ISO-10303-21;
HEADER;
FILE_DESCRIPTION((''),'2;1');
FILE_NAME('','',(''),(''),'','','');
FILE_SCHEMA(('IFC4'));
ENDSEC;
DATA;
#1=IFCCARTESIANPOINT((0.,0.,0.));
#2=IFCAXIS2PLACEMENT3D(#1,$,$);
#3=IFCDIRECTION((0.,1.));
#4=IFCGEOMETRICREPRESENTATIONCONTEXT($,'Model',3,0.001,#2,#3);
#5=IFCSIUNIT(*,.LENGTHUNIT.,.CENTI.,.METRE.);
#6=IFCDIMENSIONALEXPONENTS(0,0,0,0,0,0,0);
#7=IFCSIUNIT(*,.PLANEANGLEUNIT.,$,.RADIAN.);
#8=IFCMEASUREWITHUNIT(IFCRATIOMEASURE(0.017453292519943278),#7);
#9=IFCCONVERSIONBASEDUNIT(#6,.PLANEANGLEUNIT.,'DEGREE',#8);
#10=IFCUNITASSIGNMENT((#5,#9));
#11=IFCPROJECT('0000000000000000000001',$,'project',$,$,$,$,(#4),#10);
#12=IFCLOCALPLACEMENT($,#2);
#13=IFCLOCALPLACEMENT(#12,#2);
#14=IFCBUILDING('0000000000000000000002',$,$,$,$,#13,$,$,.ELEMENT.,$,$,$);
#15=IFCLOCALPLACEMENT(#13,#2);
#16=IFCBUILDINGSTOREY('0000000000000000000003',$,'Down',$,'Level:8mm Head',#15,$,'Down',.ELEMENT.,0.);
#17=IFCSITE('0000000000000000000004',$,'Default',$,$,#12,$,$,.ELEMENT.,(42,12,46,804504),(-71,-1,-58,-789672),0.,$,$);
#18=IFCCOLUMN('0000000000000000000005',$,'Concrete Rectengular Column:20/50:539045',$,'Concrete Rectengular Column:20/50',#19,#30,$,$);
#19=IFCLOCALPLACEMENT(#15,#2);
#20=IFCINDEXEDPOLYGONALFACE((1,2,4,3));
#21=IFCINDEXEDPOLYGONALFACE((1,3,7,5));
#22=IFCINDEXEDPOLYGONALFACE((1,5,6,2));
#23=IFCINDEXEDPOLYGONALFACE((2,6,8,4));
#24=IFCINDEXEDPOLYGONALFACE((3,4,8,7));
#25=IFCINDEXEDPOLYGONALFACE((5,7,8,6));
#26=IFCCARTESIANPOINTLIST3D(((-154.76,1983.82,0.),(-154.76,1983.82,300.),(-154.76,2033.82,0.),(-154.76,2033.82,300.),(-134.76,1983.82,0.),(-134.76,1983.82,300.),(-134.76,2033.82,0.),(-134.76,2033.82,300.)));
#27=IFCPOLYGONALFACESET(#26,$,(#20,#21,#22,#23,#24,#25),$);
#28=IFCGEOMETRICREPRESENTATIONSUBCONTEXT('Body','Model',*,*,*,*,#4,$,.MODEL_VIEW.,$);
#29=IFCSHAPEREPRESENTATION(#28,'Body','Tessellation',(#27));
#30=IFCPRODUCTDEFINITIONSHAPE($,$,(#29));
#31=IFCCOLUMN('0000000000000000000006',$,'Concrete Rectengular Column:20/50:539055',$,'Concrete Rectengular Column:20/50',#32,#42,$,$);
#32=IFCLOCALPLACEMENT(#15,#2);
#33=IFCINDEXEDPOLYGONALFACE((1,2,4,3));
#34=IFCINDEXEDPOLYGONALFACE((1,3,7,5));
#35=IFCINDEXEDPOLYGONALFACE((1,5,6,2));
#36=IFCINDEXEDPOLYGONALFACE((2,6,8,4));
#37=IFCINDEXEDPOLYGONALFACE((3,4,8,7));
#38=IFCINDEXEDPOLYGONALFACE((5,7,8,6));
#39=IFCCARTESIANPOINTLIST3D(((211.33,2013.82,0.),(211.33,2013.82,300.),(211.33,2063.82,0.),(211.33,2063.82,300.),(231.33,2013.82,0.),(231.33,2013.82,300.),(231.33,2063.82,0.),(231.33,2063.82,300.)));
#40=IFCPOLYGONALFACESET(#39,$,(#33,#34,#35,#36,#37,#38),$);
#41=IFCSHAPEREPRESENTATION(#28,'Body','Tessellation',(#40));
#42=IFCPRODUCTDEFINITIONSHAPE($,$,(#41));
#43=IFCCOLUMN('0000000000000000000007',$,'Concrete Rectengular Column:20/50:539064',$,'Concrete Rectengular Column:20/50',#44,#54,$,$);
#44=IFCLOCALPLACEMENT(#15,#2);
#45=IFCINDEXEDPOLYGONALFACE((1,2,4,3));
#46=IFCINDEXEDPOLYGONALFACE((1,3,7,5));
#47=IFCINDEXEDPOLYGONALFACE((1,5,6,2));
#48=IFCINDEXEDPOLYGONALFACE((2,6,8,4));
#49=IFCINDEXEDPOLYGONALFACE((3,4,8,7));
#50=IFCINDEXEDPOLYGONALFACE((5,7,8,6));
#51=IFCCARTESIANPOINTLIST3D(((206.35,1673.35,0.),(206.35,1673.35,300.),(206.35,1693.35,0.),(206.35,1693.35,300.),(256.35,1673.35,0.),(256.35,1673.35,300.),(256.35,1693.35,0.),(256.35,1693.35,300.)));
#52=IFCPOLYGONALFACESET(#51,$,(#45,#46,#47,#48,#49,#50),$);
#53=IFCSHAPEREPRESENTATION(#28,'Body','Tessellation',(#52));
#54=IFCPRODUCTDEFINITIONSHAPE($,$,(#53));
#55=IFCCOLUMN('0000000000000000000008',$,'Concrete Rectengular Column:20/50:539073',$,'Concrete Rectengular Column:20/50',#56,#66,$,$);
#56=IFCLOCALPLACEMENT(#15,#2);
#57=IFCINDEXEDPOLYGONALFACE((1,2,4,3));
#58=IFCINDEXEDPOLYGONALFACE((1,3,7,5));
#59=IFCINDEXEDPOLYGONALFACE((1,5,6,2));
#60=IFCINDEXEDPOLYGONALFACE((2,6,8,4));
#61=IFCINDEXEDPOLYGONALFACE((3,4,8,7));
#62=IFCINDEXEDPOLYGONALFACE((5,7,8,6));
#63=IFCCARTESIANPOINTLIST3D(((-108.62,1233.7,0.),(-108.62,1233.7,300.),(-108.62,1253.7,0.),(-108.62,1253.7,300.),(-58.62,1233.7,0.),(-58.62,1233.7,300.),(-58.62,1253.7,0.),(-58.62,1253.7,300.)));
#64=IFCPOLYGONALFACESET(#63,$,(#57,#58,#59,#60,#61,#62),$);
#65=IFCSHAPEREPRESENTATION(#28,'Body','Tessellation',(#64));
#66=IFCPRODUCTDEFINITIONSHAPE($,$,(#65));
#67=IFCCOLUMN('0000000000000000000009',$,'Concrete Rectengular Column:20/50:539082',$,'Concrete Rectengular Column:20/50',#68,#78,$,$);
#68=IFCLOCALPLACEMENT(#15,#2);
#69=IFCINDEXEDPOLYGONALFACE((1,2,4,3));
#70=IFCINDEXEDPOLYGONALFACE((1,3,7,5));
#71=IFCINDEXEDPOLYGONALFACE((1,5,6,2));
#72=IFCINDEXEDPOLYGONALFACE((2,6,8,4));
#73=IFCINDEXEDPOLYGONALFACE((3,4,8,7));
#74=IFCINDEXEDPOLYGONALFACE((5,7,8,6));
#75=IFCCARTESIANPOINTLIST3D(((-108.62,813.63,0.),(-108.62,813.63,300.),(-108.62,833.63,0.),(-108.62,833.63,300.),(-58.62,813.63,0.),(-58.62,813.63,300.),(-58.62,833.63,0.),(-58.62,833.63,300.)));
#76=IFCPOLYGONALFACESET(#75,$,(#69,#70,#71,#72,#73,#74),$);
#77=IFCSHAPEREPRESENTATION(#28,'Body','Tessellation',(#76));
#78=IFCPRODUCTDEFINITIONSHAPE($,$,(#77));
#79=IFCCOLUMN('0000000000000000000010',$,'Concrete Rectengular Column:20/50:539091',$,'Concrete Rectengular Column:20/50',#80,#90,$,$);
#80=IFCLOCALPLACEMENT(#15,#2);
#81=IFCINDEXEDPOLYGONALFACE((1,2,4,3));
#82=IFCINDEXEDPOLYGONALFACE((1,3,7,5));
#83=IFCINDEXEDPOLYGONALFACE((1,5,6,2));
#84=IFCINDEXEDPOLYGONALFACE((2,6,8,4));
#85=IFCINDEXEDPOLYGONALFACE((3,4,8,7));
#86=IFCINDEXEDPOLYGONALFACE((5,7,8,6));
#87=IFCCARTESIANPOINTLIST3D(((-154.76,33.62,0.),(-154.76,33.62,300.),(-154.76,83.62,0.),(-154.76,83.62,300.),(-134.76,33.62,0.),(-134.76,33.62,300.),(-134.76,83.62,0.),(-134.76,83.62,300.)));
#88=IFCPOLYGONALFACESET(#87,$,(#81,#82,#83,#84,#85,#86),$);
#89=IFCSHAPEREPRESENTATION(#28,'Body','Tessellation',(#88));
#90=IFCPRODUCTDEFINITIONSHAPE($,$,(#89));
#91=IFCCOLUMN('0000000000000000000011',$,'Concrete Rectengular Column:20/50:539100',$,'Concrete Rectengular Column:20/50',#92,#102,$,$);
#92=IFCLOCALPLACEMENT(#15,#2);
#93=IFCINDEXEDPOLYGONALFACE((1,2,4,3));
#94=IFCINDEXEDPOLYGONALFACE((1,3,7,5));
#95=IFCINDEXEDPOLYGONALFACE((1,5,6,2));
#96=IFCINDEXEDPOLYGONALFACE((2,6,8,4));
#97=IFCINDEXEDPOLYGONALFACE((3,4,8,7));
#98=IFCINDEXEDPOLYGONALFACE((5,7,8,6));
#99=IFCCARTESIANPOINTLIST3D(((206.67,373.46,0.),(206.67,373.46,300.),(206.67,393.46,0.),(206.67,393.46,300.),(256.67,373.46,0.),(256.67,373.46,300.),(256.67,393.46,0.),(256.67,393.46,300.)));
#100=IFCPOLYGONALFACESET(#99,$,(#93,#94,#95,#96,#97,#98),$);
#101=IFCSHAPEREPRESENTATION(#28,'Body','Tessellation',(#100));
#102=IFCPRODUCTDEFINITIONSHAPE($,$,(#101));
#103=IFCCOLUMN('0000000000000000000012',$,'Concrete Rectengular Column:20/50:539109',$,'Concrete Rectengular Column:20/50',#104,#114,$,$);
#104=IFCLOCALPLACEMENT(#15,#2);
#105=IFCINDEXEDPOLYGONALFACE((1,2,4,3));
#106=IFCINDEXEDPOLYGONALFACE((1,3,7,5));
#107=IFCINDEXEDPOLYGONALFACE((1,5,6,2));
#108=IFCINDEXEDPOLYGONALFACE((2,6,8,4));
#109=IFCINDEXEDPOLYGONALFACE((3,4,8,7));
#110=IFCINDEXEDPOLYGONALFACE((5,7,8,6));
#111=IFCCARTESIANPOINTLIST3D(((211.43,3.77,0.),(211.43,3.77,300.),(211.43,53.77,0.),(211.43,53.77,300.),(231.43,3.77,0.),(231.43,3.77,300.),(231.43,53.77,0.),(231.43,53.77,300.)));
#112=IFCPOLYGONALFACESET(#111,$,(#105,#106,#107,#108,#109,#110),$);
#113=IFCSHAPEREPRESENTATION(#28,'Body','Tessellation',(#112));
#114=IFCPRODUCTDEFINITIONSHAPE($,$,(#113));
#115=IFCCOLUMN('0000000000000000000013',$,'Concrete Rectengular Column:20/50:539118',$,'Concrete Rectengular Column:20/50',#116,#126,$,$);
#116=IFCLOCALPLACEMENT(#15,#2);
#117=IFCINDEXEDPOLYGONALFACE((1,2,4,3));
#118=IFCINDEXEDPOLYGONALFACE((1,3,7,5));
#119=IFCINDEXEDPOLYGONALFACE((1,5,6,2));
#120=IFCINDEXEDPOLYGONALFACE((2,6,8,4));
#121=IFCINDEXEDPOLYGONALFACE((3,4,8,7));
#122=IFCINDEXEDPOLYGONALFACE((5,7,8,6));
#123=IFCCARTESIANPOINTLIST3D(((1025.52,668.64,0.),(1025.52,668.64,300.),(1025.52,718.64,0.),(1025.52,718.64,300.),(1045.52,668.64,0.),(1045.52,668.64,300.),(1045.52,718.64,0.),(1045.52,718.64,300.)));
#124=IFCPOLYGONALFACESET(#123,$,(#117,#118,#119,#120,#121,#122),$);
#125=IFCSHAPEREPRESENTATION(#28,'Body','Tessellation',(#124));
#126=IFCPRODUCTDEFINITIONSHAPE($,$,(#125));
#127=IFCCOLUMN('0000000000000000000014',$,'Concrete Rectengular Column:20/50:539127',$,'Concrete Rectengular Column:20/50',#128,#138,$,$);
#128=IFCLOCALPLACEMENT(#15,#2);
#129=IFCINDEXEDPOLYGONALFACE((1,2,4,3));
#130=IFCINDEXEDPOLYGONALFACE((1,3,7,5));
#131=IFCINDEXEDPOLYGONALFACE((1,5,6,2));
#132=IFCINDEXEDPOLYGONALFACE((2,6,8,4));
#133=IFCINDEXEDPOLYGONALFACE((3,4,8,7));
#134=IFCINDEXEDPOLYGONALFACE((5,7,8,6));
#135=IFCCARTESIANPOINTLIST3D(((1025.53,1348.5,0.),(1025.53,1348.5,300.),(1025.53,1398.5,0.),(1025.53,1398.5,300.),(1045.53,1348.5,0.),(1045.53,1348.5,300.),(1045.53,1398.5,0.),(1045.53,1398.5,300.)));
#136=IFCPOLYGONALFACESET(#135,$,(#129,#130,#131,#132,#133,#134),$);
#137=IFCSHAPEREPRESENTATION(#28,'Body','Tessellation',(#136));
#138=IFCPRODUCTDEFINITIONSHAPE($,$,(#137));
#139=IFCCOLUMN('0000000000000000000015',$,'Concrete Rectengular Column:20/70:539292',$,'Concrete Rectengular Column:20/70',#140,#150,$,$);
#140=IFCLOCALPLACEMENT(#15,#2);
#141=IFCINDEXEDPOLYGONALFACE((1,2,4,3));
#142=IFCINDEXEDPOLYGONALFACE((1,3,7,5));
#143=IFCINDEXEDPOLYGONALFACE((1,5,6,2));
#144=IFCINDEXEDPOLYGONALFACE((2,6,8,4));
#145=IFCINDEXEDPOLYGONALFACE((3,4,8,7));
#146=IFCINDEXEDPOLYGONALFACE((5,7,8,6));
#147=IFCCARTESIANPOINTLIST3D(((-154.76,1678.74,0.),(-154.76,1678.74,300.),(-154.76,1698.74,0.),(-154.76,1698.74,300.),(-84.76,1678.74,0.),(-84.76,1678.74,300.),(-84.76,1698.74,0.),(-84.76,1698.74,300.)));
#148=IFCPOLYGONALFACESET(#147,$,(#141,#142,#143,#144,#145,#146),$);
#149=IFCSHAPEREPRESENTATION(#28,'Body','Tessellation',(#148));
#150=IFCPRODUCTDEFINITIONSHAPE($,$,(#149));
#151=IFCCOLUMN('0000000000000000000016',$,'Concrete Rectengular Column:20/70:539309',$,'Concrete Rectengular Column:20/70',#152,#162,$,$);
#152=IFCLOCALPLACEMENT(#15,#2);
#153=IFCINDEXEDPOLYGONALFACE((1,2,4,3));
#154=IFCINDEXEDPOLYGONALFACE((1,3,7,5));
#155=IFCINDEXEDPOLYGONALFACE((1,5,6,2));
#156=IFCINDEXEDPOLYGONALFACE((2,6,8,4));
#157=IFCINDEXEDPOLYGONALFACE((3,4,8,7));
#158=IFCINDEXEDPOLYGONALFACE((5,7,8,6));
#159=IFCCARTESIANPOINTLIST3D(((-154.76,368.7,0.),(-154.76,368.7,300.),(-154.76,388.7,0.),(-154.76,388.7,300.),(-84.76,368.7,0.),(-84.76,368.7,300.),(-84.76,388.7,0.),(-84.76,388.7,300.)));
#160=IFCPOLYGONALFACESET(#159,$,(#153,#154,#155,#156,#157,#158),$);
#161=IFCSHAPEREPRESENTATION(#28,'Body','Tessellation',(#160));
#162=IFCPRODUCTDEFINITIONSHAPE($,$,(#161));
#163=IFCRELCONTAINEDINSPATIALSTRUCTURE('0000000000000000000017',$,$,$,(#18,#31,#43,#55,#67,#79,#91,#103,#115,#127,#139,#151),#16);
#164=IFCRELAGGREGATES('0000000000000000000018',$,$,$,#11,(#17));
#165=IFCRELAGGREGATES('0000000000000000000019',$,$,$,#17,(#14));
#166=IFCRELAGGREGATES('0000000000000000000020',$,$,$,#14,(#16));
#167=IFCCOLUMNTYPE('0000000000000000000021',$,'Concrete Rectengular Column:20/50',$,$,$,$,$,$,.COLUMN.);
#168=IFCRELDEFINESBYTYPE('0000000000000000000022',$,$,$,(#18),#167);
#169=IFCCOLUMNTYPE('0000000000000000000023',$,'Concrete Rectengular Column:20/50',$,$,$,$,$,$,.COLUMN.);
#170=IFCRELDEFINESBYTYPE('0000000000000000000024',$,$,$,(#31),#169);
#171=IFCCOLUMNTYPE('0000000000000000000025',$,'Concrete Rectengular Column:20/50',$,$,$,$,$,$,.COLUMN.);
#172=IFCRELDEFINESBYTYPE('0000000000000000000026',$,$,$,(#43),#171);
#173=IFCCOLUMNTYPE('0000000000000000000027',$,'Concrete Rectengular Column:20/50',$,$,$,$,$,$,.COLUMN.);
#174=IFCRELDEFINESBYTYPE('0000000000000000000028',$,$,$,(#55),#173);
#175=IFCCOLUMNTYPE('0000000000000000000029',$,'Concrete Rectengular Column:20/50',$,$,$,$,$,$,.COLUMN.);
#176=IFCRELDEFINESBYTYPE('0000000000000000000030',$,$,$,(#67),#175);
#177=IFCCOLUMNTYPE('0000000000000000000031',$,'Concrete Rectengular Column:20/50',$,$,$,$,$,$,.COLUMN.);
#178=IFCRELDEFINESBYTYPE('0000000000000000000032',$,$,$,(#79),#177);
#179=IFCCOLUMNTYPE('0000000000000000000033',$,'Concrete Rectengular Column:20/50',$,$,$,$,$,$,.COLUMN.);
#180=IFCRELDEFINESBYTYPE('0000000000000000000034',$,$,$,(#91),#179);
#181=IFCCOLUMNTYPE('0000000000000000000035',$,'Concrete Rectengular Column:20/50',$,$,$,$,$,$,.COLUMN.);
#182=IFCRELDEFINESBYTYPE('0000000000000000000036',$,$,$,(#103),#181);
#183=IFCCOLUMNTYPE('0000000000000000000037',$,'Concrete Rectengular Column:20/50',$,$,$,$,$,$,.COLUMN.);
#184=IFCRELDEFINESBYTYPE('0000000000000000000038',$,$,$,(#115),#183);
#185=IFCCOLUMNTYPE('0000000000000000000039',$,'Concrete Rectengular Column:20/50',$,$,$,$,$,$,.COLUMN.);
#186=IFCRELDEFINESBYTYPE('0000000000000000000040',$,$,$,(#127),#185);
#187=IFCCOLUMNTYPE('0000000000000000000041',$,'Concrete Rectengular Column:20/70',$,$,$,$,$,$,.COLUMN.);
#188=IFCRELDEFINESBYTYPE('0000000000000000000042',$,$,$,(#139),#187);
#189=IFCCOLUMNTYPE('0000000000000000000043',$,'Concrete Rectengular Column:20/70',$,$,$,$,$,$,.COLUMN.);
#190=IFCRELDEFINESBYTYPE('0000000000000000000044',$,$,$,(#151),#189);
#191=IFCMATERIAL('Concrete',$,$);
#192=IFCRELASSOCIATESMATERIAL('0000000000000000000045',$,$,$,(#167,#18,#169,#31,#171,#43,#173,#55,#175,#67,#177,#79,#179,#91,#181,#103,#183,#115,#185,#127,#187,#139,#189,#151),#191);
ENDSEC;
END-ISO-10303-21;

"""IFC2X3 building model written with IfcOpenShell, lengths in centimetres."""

from ifc_helpers import new_model, entity, si_unit, converted_unit, direction, frame, frame_2d, origin, origin_2d_with_axis, place, context, subcontext, project, spatial, rectangle, extrude, source, transform, mapped, material, type_object, type_shapes, element, save


model = new_model("IFC2X3")

# Units and contexts
model_context = context("Model", 3, precision=0.001, world=origin(), true_north=direction((0.0, 1.0)))
body_context = subcontext(model_context, "Body", "Model", "MODEL_VIEW")
ifc_project = project(units=[si_unit("LENGTHUNIT", "METRE", prefix="CENTI"), converted_unit("PLANEANGLEUNIT", "DEGREE", entity("IfcRatioMeasure", 0.017453292519943278), si_unit("PLANEANGLEUNIT", "RADIAN"), dimensions=[0, 0, 0, 0, 0, 0, 0])], contexts=[model_context])

# Site, building, storey
site_placement = place(None, origin())
site = spatial("IfcSite", under=ifc_project, at=site_placement, Name="Default", CompositionType="ELEMENT", RefLatitude=(42, 12, 46, 804504), RefLongitude=(-71, -1, -58, -789672), RefElevation=0.0)
building_placement = place(site_placement, origin())
building = spatial("IfcBuilding", under=site, at=building_placement, CompositionType="ELEMENT")
storey_placement = place(building_placement, origin())
storey = spatial("IfcBuildingStorey", under=building, at=storey_placement, Name="Down", ObjectType="Level:8mm Head", LongName="Down", CompositionType="ELEMENT", Elevation=0.0)

# Columns
ifc_material = material(Name="Concrete")
column_type_1 = type_object("IfcColumnType", Name="Concrete Rectengular Column:20/50", PredefinedType="COLUMN", material=ifc_material)
shared_shape_1 = source(origin(), body_context, "Body", "SweptSolid", [
    extrude(rectangle(XDim=50.0, YDim=20.0, at=frame_2d((0.0, 0.0), x_axis=(1.0, 0.0))), frame((-144.76, 2008.82, 0.0), z_axis=(0.0, 0.0, 1.0), x_axis=(0.0, -1.0, 0.0)), (0.0, 0.0, 1.0), 300.0),
])
type_shapes(column_type_1, [shared_shape_1])
column_1_placement = place(storey_placement, origin())
element("IfcColumn", 1, at=column_1_placement, inside=storey, type_object=column_type_1, material=ifc_material, Name="Concrete Rectengular Column:20/50:539045", ObjectType="Concrete Rectengular Column:20/50", context=body_context, shape_type="MappedRepresentation", body=[
    mapped(shared_shape_1, transform((0.0, 0.0, 0.0), scale=1.0)),
])
column_type_2 = type_object("IfcColumnType", Name="Concrete Rectengular Column:20/50", PredefinedType="COLUMN", material=ifc_material)
shared_shape_2 = source(origin(), body_context, "Body", "SweptSolid", [
    extrude(rectangle(XDim=50.0, YDim=20.0, at=frame_2d((0.0, 0.0), x_axis=(1.0, 0.0))), frame((221.33, 2038.82, 0.0), z_axis=(0.0, 0.0, 1.0), x_axis=(0.0, -1.0, 0.0)), (0.0, 0.0, 1.0), 300.0),
])
type_shapes(column_type_2, [shared_shape_2])
column_2_placement = place(storey_placement, origin())
element("IfcColumn", 2, at=column_2_placement, inside=storey, type_object=column_type_2, material=ifc_material, Name="Concrete Rectengular Column:20/50:539055", ObjectType="Concrete Rectengular Column:20/50", context=body_context, shape_type="MappedRepresentation", body=[
    mapped(shared_shape_2, transform((0.0, 0.0, 0.0), scale=1.0)),
])
column_type_3 = type_object("IfcColumnType", Name="Concrete Rectengular Column:20/50", PredefinedType="COLUMN", material=ifc_material)
shared_shape_3 = source(origin(), body_context, "Body", "SweptSolid", [
    extrude(rectangle(XDim=20.0, YDim=50.0, at=frame_2d((0.0, 0.0), x_axis=(1.0, 0.0))), frame((231.35, 1683.35, 0.0), z_axis=(0.0, 0.0, 1.0), x_axis=(0.0, -1.0, 0.0)), (0.0, 0.0, 1.0), 300.0),
])
type_shapes(column_type_3, [shared_shape_3])
column_3_placement = place(storey_placement, origin())
element("IfcColumn", 3, at=column_3_placement, inside=storey, type_object=column_type_3, material=ifc_material, Name="Concrete Rectengular Column:20/50:539064", ObjectType="Concrete Rectengular Column:20/50", context=body_context, shape_type="MappedRepresentation", body=[
    mapped(shared_shape_3, transform((0.0, 0.0, 0.0), scale=1.0)),
])
column_type_4 = type_object("IfcColumnType", Name="Concrete Rectengular Column:20/50", PredefinedType="COLUMN", material=ifc_material)
shared_shape_4 = source(origin(), body_context, "Body", "SweptSolid", [
    extrude(rectangle(XDim=20.0, YDim=50.0, at=frame_2d((0.0, 0.0), x_axis=(1.0, 0.0))), frame((-83.62, 1243.7, 0.0), z_axis=(0.0, 0.0, 1.0), x_axis=(0.0, -1.0, 0.0)), (0.0, 0.0, 1.0), 300.0),
])
type_shapes(column_type_4, [shared_shape_4])
column_4_placement = place(storey_placement, origin())
element("IfcColumn", 4, at=column_4_placement, inside=storey, type_object=column_type_4, material=ifc_material, Name="Concrete Rectengular Column:20/50:539073", ObjectType="Concrete Rectengular Column:20/50", context=body_context, shape_type="MappedRepresentation", body=[
    mapped(shared_shape_4, transform((0.0, 0.0, 0.0), scale=1.0)),
])
column_type_5 = type_object("IfcColumnType", Name="Concrete Rectengular Column:20/50", PredefinedType="COLUMN", material=ifc_material)
shared_shape_5 = source(origin(), body_context, "Body", "SweptSolid", [
    extrude(rectangle(XDim=20.0, YDim=50.0, at=frame_2d((0.0, 0.0), x_axis=(1.0, 0.0))), frame((-83.62, 823.63, 0.0), z_axis=(0.0, 0.0, 1.0), x_axis=(0.0, -1.0, 0.0)), (0.0, 0.0, 1.0), 300.0),
])
type_shapes(column_type_5, [shared_shape_5])
column_5_placement = place(storey_placement, origin())
element("IfcColumn", 5, at=column_5_placement, inside=storey, type_object=column_type_5, material=ifc_material, Name="Concrete Rectengular Column:20/50:539082", ObjectType="Concrete Rectengular Column:20/50", context=body_context, shape_type="MappedRepresentation", body=[
    mapped(shared_shape_5, transform((0.0, 0.0, 0.0), scale=1.0)),
])
column_type_6 = type_object("IfcColumnType", Name="Concrete Rectengular Column:20/50", PredefinedType="COLUMN", material=ifc_material)
shared_shape_6 = source(origin(), body_context, "Body", "SweptSolid", [
    extrude(rectangle(XDim=50.0, YDim=20.0, at=frame_2d((0.0, 0.0), x_axis=(1.0, 0.0))), frame((-144.76, 58.62, 0.0), z_axis=(0.0, 0.0, 1.0), x_axis=(0.0, -1.0, 0.0)), (0.0, 0.0, 1.0), 300.0),
])
type_shapes(column_type_6, [shared_shape_6])
column_6_placement = place(storey_placement, origin())
element("IfcColumn", 6, at=column_6_placement, inside=storey, type_object=column_type_6, material=ifc_material, Name="Concrete Rectengular Column:20/50:539091", ObjectType="Concrete Rectengular Column:20/50", context=body_context, shape_type="MappedRepresentation", body=[
    mapped(shared_shape_6, transform((0.0, 0.0, 0.0), scale=1.0)),
])
column_type_7 = type_object("IfcColumnType", Name="Concrete Rectengular Column:20/50", PredefinedType="COLUMN", material=ifc_material)
shared_shape_7 = source(origin(), body_context, "Body", "SweptSolid", [
    extrude(rectangle(XDim=20.0, YDim=50.0, at=origin_2d_with_axis()), frame((231.67, 383.46, 0.0), z_axis=(0.0, 0.0, 1.0), x_axis=(0.0, -1.0, 0.0)), (0.0, 0.0, 1.0), 300.0),
])
type_shapes(column_type_7, [shared_shape_7])
column_7_placement = place(storey_placement, origin())
element("IfcColumn", 7, at=column_7_placement, inside=storey, type_object=column_type_7, material=ifc_material, Name="Concrete Rectengular Column:20/50:539100", ObjectType="Concrete Rectengular Column:20/50", context=body_context, shape_type="MappedRepresentation", body=[
    mapped(shared_shape_7, transform((0.0, 0.0, 0.0), scale=1.0)),
])
column_type_8 = type_object("IfcColumnType", Name="Concrete Rectengular Column:20/50", PredefinedType="COLUMN", material=ifc_material)
shared_shape_8 = source(origin(), body_context, "Body", "SweptSolid", [
    extrude(rectangle(XDim=50.0, YDim=20.0, at=frame_2d((0.0, 0.0), x_axis=(1.0, 0.0))), frame((221.43, 28.77, 0.0), z_axis=(0.0, 0.0, 1.0), x_axis=(0.0, -1.0, 0.0)), (0.0, 0.0, 1.0), 300.0),
])
type_shapes(column_type_8, [shared_shape_8])
column_8_placement = place(storey_placement, origin())
element("IfcColumn", 8, at=column_8_placement, inside=storey, type_object=column_type_8, material=ifc_material, Name="Concrete Rectengular Column:20/50:539109", ObjectType="Concrete Rectengular Column:20/50", context=body_context, shape_type="MappedRepresentation", body=[
    mapped(shared_shape_8, transform((0.0, 0.0, 0.0), scale=1.0)),
])
column_type_9 = type_object("IfcColumnType", Name="Concrete Rectengular Column:20/50", PredefinedType="COLUMN", material=ifc_material)
shared_shape_9 = source(origin(), body_context, "Body", "SweptSolid", [
    extrude(rectangle(XDim=50.0, YDim=20.0, at=frame_2d((0.0, 0.0), x_axis=(1.0, 0.0))), frame((1035.52, 693.64, 0.0), z_axis=(0.0, 0.0, 1.0), x_axis=(0.0, -1.0, 0.0)), (0.0, 0.0, 1.0), 300.0),
])
type_shapes(column_type_9, [shared_shape_9])
column_9_placement = place(storey_placement, origin())
element("IfcColumn", 9, at=column_9_placement, inside=storey, type_object=column_type_9, material=ifc_material, Name="Concrete Rectengular Column:20/50:539118", ObjectType="Concrete Rectengular Column:20/50", context=body_context, shape_type="MappedRepresentation", body=[
    mapped(shared_shape_9, transform((0.0, 0.0, 0.0), scale=1.0)),
])
column_type_10 = type_object("IfcColumnType", Name="Concrete Rectengular Column:20/50", PredefinedType="COLUMN", material=ifc_material)
shared_shape_10 = source(origin(), body_context, "Body", "SweptSolid", [
    extrude(rectangle(XDim=50.0, YDim=20.0, at=frame_2d((0.0, 0.0), x_axis=(1.0, 0.0))), frame((1035.53, 1373.5, 0.0), z_axis=(0.0, 0.0, 1.0), x_axis=(0.0, -1.0, 0.0)), (0.0, 0.0, 1.0), 300.0),
])
type_shapes(column_type_10, [shared_shape_10])
column_10_placement = place(storey_placement, origin())
element("IfcColumn", 10, at=column_10_placement, inside=storey, type_object=column_type_10, material=ifc_material, Name="Concrete Rectengular Column:20/50:539127", ObjectType="Concrete Rectengular Column:20/50", context=body_context, shape_type="MappedRepresentation", body=[
    mapped(shared_shape_10, transform((0.0, 0.0, 0.0), scale=1.0)),
])
column_type_11 = type_object("IfcColumnType", Name="Concrete Rectengular Column:20/70", PredefinedType="COLUMN", material=ifc_material)
shared_shape_11 = source(origin(), body_context, "Body", "SweptSolid", [
    extrude(rectangle(XDim=20.0, YDim=70.0, at=frame_2d((0.0, 0.0), x_axis=(1.0, 0.0))), frame((-119.76, 1688.74, 0.0), z_axis=(0.0, 0.0, 1.0), x_axis=(0.0, -1.0, 0.0)), (0.0, 0.0, 1.0), 300.0),
])
type_shapes(column_type_11, [shared_shape_11])
column_11_placement = place(storey_placement, origin())
element("IfcColumn", 11, at=column_11_placement, inside=storey, type_object=column_type_11, material=ifc_material, Name="Concrete Rectengular Column:20/70:539292", ObjectType="Concrete Rectengular Column:20/70", context=body_context, shape_type="MappedRepresentation", body=[
    mapped(shared_shape_11, transform((0.0, 0.0, 0.0), scale=1.0)),
])
column_type_12 = type_object("IfcColumnType", Name="Concrete Rectengular Column:20/70", PredefinedType="COLUMN", material=ifc_material)
shared_shape_12 = source(origin(), body_context, "Body", "SweptSolid", [
    extrude(rectangle(XDim=20.0, YDim=70.0, at=frame_2d((0.0, 0.0), x_axis=(1.0, 0.0))), frame((-119.76, 378.7, 0.0), z_axis=(0.0, 0.0, 1.0), x_axis=(0.0, -1.0, 0.0)), (0.0, 0.0, 1.0), 300.0),
])
type_shapes(column_type_12, [shared_shape_12])
column_12_placement = place(storey_placement, origin())
element("IfcColumn", 12, at=column_12_placement, inside=storey, type_object=column_type_12, material=ifc_material, Name="Concrete Rectengular Column:20/70:539309", ObjectType="Concrete Rectengular Column:20/70", context=body_context, shape_type="MappedRepresentation", body=[
    mapped(shared_shape_12, transform((0.0, 0.0, 0.0), scale=1.0)),
])

save(model, "model.ifc")
